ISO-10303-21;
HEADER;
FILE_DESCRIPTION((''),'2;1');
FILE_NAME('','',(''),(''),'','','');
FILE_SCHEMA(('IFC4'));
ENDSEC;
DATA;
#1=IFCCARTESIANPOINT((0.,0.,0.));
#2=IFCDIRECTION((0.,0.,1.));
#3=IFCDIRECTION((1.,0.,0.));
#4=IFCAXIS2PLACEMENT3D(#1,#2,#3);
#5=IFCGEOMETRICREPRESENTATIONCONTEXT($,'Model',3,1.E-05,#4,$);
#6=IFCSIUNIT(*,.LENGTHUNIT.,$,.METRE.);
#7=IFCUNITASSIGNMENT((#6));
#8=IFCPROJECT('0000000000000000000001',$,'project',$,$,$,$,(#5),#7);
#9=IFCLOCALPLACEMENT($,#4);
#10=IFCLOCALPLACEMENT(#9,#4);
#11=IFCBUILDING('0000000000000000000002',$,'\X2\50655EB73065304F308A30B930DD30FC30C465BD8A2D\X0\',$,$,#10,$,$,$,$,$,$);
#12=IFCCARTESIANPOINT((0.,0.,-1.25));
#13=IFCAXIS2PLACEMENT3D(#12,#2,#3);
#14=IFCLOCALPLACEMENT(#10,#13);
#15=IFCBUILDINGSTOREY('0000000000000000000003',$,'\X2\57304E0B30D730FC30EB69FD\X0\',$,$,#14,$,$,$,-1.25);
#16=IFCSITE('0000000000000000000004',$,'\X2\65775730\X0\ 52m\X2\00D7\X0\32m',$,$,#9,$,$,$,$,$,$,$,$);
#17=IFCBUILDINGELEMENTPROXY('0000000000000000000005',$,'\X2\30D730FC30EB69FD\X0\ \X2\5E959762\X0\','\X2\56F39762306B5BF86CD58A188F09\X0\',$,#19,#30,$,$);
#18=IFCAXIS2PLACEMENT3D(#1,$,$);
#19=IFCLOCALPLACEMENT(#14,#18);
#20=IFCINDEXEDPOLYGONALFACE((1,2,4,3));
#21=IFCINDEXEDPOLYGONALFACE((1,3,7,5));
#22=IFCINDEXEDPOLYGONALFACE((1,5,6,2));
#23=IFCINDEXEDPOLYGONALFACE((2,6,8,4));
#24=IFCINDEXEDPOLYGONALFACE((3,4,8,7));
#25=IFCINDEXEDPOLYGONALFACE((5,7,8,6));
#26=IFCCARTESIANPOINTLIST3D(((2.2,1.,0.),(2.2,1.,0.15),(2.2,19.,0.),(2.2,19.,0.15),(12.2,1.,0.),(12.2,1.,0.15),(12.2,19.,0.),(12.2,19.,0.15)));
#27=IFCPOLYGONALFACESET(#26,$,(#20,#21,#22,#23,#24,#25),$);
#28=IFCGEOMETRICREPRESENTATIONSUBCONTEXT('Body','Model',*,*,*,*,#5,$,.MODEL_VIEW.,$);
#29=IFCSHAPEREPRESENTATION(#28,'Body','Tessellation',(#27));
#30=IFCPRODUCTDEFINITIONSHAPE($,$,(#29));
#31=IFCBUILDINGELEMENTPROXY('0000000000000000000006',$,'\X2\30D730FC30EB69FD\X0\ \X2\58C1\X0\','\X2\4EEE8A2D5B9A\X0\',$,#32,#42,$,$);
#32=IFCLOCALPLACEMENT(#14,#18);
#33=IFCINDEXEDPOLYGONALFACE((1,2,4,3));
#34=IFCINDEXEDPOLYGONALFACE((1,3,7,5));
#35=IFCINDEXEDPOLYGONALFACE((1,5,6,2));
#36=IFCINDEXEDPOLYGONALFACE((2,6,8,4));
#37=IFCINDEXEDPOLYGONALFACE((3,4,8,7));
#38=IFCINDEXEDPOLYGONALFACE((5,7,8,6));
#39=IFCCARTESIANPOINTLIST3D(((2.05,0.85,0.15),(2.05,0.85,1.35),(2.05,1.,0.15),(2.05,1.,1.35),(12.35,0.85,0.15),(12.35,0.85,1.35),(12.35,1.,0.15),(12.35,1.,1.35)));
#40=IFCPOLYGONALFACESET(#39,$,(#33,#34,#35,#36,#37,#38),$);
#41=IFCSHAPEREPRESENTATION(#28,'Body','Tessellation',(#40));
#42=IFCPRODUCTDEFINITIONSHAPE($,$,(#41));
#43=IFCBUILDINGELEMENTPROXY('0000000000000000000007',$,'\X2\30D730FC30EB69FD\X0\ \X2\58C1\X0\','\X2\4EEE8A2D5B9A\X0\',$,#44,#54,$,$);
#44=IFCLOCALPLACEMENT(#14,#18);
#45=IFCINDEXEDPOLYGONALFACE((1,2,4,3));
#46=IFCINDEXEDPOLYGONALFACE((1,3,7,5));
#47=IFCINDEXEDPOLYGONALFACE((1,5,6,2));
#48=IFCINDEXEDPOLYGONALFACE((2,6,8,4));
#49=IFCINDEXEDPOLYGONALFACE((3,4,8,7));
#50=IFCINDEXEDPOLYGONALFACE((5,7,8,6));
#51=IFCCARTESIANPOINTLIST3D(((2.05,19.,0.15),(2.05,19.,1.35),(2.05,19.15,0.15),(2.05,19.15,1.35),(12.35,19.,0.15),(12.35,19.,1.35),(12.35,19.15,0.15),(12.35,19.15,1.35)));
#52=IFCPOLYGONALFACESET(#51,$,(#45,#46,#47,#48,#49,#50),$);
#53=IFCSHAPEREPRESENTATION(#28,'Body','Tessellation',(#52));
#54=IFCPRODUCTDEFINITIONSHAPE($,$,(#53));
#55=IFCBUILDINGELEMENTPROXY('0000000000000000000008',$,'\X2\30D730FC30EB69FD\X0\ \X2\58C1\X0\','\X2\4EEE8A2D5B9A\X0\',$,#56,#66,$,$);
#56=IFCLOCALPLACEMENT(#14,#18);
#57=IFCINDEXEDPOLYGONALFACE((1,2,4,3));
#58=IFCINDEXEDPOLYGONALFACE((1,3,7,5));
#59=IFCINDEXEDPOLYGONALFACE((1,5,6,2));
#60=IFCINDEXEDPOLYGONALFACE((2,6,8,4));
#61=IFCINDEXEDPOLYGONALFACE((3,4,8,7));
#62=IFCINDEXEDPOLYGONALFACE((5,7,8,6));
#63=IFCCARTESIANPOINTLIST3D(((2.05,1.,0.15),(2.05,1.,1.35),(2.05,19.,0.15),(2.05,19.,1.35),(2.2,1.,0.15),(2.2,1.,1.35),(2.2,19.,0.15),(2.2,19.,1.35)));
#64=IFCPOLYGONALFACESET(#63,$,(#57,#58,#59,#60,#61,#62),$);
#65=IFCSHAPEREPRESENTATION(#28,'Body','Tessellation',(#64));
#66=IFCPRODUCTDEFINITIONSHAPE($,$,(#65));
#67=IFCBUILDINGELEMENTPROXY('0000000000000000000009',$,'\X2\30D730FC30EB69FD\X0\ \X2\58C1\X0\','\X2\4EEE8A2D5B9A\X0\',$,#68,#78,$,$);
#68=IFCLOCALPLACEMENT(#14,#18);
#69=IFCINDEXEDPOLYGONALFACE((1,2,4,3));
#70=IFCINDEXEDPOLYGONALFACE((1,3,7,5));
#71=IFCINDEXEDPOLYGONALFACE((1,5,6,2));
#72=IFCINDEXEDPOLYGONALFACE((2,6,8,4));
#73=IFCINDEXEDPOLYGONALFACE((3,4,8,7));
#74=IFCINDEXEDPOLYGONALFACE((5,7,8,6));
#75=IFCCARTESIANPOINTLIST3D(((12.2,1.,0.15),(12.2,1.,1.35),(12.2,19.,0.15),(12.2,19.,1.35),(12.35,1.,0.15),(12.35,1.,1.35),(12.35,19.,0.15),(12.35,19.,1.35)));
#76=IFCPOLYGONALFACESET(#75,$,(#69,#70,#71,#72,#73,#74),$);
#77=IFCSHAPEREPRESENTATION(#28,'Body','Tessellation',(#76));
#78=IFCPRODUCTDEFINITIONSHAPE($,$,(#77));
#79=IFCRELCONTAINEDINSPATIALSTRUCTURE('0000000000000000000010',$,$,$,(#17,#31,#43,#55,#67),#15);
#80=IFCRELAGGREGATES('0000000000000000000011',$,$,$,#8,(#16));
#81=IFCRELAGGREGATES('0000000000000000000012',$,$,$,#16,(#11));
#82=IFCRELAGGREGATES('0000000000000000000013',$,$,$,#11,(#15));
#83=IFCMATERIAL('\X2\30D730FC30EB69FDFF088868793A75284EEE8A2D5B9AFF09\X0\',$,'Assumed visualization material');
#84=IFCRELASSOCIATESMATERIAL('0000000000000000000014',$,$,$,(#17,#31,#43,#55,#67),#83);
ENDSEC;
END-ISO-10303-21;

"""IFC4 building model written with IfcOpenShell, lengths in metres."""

from ifc_helpers import new_model, si_unit, frame, origin_with_axes, place, context, subcontext, project, spatial, rectangle, extrude, material, element, save


model = new_model("IFC4")

# Units and contexts
model_context = context("Model", 3, precision=1e-05, world=origin_with_axes())
body_context = subcontext(model_context, "Body", "Model", "MODEL_VIEW")
ifc_project = project(units=[si_unit("LENGTHUNIT", "METRE")], contexts=[model_context])

# Site, building, storey
site_placement = place(None, origin_with_axes())
site = spatial("IfcSite", under=ifc_project, at=site_placement, Name="敷地 52m×32m")
building_placement = place(site_placement, origin_with_axes())
building = spatial("IfcBuilding", under=site, at=building_placement, Name="健康づくりスポーツ施設")
storey_placement = place(building_placement, frame((0.0, 0.0, -1.25), z_axis=(0.0, 0.0, 1.0), x_axis=(1.0, 0.0, 0.0)))
storey = spatial("IfcBuildingStorey", under=building, at=storey_placement, Name="地下プール槽", Elevation=-1.25)

# Building element proxies
ifc_material = material(Name="プール槽（表示用仮設定）", Category="Assumed visualization material")
proxy_placement = place(storey_placement, frame((7.2, 10.0, 0.0), z_axis=(0.0, 0.0, 1.0), x_axis=(1.0, 0.0, 0.0)))
element("IfcBuildingElementProxy", 1, at=proxy_placement, inside=storey, material=ifc_material, Name="プール槽 底面", Description="図面に寸法記載", context=body_context, shape_type="SweptSolid", body=[
    extrude(rectangle(XDim=10.0, YDim=18.0), origin_with_axes(), (0.0, 0.0, 1.0), 0.15),
])
for number, where, z_axis, x_axis, name in (
    (2, (7.2, 0.925, 0.15), (0.0, 0.0, 1.0), (1.0, 0.0, 0.0), "プール槽 壁"),
    (3, (7.2, 19.075, 0.15), (0.0, 0.0, 1.0), (1.0, 0.0, 0.0), "プール槽 壁"),
):
    element("IfcBuildingElementProxy", number, at=place(storey_placement, frame(where, z_axis=z_axis, x_axis=x_axis)), inside=storey, material=ifc_material, Name=name, Description="仮設定", context=body_context, shape_type="SweptSolid", body=[
        extrude(rectangle(XDim=10.3, YDim=0.15), origin_with_axes(), (0.0, 0.0, 1.0), 1.2),
    ])
for number, where, z_axis, x_axis, name in (
    (4, (2.125, 10.0, 0.15), (0.0, 0.0, 1.0), (1.0, 0.0, 0.0), "プール槽 壁"),
    (5, (12.275, 10.0, 0.15), (0.0, 0.0, 1.0), (1.0, 0.0, 0.0), "プール槽 壁"),
):
    element("IfcBuildingElementProxy", number, at=place(storey_placement, frame(where, z_axis=z_axis, x_axis=x_axis)), inside=storey, material=ifc_material, Name=name, Description="仮設定", context=body_context, shape_type="SweptSolid", body=[
        extrude(rectangle(XDim=0.15, YDim=18.0), origin_with_axes(), (0.0, 0.0, 1.0), 1.2),
    ])

save(model, "model.ifc")
